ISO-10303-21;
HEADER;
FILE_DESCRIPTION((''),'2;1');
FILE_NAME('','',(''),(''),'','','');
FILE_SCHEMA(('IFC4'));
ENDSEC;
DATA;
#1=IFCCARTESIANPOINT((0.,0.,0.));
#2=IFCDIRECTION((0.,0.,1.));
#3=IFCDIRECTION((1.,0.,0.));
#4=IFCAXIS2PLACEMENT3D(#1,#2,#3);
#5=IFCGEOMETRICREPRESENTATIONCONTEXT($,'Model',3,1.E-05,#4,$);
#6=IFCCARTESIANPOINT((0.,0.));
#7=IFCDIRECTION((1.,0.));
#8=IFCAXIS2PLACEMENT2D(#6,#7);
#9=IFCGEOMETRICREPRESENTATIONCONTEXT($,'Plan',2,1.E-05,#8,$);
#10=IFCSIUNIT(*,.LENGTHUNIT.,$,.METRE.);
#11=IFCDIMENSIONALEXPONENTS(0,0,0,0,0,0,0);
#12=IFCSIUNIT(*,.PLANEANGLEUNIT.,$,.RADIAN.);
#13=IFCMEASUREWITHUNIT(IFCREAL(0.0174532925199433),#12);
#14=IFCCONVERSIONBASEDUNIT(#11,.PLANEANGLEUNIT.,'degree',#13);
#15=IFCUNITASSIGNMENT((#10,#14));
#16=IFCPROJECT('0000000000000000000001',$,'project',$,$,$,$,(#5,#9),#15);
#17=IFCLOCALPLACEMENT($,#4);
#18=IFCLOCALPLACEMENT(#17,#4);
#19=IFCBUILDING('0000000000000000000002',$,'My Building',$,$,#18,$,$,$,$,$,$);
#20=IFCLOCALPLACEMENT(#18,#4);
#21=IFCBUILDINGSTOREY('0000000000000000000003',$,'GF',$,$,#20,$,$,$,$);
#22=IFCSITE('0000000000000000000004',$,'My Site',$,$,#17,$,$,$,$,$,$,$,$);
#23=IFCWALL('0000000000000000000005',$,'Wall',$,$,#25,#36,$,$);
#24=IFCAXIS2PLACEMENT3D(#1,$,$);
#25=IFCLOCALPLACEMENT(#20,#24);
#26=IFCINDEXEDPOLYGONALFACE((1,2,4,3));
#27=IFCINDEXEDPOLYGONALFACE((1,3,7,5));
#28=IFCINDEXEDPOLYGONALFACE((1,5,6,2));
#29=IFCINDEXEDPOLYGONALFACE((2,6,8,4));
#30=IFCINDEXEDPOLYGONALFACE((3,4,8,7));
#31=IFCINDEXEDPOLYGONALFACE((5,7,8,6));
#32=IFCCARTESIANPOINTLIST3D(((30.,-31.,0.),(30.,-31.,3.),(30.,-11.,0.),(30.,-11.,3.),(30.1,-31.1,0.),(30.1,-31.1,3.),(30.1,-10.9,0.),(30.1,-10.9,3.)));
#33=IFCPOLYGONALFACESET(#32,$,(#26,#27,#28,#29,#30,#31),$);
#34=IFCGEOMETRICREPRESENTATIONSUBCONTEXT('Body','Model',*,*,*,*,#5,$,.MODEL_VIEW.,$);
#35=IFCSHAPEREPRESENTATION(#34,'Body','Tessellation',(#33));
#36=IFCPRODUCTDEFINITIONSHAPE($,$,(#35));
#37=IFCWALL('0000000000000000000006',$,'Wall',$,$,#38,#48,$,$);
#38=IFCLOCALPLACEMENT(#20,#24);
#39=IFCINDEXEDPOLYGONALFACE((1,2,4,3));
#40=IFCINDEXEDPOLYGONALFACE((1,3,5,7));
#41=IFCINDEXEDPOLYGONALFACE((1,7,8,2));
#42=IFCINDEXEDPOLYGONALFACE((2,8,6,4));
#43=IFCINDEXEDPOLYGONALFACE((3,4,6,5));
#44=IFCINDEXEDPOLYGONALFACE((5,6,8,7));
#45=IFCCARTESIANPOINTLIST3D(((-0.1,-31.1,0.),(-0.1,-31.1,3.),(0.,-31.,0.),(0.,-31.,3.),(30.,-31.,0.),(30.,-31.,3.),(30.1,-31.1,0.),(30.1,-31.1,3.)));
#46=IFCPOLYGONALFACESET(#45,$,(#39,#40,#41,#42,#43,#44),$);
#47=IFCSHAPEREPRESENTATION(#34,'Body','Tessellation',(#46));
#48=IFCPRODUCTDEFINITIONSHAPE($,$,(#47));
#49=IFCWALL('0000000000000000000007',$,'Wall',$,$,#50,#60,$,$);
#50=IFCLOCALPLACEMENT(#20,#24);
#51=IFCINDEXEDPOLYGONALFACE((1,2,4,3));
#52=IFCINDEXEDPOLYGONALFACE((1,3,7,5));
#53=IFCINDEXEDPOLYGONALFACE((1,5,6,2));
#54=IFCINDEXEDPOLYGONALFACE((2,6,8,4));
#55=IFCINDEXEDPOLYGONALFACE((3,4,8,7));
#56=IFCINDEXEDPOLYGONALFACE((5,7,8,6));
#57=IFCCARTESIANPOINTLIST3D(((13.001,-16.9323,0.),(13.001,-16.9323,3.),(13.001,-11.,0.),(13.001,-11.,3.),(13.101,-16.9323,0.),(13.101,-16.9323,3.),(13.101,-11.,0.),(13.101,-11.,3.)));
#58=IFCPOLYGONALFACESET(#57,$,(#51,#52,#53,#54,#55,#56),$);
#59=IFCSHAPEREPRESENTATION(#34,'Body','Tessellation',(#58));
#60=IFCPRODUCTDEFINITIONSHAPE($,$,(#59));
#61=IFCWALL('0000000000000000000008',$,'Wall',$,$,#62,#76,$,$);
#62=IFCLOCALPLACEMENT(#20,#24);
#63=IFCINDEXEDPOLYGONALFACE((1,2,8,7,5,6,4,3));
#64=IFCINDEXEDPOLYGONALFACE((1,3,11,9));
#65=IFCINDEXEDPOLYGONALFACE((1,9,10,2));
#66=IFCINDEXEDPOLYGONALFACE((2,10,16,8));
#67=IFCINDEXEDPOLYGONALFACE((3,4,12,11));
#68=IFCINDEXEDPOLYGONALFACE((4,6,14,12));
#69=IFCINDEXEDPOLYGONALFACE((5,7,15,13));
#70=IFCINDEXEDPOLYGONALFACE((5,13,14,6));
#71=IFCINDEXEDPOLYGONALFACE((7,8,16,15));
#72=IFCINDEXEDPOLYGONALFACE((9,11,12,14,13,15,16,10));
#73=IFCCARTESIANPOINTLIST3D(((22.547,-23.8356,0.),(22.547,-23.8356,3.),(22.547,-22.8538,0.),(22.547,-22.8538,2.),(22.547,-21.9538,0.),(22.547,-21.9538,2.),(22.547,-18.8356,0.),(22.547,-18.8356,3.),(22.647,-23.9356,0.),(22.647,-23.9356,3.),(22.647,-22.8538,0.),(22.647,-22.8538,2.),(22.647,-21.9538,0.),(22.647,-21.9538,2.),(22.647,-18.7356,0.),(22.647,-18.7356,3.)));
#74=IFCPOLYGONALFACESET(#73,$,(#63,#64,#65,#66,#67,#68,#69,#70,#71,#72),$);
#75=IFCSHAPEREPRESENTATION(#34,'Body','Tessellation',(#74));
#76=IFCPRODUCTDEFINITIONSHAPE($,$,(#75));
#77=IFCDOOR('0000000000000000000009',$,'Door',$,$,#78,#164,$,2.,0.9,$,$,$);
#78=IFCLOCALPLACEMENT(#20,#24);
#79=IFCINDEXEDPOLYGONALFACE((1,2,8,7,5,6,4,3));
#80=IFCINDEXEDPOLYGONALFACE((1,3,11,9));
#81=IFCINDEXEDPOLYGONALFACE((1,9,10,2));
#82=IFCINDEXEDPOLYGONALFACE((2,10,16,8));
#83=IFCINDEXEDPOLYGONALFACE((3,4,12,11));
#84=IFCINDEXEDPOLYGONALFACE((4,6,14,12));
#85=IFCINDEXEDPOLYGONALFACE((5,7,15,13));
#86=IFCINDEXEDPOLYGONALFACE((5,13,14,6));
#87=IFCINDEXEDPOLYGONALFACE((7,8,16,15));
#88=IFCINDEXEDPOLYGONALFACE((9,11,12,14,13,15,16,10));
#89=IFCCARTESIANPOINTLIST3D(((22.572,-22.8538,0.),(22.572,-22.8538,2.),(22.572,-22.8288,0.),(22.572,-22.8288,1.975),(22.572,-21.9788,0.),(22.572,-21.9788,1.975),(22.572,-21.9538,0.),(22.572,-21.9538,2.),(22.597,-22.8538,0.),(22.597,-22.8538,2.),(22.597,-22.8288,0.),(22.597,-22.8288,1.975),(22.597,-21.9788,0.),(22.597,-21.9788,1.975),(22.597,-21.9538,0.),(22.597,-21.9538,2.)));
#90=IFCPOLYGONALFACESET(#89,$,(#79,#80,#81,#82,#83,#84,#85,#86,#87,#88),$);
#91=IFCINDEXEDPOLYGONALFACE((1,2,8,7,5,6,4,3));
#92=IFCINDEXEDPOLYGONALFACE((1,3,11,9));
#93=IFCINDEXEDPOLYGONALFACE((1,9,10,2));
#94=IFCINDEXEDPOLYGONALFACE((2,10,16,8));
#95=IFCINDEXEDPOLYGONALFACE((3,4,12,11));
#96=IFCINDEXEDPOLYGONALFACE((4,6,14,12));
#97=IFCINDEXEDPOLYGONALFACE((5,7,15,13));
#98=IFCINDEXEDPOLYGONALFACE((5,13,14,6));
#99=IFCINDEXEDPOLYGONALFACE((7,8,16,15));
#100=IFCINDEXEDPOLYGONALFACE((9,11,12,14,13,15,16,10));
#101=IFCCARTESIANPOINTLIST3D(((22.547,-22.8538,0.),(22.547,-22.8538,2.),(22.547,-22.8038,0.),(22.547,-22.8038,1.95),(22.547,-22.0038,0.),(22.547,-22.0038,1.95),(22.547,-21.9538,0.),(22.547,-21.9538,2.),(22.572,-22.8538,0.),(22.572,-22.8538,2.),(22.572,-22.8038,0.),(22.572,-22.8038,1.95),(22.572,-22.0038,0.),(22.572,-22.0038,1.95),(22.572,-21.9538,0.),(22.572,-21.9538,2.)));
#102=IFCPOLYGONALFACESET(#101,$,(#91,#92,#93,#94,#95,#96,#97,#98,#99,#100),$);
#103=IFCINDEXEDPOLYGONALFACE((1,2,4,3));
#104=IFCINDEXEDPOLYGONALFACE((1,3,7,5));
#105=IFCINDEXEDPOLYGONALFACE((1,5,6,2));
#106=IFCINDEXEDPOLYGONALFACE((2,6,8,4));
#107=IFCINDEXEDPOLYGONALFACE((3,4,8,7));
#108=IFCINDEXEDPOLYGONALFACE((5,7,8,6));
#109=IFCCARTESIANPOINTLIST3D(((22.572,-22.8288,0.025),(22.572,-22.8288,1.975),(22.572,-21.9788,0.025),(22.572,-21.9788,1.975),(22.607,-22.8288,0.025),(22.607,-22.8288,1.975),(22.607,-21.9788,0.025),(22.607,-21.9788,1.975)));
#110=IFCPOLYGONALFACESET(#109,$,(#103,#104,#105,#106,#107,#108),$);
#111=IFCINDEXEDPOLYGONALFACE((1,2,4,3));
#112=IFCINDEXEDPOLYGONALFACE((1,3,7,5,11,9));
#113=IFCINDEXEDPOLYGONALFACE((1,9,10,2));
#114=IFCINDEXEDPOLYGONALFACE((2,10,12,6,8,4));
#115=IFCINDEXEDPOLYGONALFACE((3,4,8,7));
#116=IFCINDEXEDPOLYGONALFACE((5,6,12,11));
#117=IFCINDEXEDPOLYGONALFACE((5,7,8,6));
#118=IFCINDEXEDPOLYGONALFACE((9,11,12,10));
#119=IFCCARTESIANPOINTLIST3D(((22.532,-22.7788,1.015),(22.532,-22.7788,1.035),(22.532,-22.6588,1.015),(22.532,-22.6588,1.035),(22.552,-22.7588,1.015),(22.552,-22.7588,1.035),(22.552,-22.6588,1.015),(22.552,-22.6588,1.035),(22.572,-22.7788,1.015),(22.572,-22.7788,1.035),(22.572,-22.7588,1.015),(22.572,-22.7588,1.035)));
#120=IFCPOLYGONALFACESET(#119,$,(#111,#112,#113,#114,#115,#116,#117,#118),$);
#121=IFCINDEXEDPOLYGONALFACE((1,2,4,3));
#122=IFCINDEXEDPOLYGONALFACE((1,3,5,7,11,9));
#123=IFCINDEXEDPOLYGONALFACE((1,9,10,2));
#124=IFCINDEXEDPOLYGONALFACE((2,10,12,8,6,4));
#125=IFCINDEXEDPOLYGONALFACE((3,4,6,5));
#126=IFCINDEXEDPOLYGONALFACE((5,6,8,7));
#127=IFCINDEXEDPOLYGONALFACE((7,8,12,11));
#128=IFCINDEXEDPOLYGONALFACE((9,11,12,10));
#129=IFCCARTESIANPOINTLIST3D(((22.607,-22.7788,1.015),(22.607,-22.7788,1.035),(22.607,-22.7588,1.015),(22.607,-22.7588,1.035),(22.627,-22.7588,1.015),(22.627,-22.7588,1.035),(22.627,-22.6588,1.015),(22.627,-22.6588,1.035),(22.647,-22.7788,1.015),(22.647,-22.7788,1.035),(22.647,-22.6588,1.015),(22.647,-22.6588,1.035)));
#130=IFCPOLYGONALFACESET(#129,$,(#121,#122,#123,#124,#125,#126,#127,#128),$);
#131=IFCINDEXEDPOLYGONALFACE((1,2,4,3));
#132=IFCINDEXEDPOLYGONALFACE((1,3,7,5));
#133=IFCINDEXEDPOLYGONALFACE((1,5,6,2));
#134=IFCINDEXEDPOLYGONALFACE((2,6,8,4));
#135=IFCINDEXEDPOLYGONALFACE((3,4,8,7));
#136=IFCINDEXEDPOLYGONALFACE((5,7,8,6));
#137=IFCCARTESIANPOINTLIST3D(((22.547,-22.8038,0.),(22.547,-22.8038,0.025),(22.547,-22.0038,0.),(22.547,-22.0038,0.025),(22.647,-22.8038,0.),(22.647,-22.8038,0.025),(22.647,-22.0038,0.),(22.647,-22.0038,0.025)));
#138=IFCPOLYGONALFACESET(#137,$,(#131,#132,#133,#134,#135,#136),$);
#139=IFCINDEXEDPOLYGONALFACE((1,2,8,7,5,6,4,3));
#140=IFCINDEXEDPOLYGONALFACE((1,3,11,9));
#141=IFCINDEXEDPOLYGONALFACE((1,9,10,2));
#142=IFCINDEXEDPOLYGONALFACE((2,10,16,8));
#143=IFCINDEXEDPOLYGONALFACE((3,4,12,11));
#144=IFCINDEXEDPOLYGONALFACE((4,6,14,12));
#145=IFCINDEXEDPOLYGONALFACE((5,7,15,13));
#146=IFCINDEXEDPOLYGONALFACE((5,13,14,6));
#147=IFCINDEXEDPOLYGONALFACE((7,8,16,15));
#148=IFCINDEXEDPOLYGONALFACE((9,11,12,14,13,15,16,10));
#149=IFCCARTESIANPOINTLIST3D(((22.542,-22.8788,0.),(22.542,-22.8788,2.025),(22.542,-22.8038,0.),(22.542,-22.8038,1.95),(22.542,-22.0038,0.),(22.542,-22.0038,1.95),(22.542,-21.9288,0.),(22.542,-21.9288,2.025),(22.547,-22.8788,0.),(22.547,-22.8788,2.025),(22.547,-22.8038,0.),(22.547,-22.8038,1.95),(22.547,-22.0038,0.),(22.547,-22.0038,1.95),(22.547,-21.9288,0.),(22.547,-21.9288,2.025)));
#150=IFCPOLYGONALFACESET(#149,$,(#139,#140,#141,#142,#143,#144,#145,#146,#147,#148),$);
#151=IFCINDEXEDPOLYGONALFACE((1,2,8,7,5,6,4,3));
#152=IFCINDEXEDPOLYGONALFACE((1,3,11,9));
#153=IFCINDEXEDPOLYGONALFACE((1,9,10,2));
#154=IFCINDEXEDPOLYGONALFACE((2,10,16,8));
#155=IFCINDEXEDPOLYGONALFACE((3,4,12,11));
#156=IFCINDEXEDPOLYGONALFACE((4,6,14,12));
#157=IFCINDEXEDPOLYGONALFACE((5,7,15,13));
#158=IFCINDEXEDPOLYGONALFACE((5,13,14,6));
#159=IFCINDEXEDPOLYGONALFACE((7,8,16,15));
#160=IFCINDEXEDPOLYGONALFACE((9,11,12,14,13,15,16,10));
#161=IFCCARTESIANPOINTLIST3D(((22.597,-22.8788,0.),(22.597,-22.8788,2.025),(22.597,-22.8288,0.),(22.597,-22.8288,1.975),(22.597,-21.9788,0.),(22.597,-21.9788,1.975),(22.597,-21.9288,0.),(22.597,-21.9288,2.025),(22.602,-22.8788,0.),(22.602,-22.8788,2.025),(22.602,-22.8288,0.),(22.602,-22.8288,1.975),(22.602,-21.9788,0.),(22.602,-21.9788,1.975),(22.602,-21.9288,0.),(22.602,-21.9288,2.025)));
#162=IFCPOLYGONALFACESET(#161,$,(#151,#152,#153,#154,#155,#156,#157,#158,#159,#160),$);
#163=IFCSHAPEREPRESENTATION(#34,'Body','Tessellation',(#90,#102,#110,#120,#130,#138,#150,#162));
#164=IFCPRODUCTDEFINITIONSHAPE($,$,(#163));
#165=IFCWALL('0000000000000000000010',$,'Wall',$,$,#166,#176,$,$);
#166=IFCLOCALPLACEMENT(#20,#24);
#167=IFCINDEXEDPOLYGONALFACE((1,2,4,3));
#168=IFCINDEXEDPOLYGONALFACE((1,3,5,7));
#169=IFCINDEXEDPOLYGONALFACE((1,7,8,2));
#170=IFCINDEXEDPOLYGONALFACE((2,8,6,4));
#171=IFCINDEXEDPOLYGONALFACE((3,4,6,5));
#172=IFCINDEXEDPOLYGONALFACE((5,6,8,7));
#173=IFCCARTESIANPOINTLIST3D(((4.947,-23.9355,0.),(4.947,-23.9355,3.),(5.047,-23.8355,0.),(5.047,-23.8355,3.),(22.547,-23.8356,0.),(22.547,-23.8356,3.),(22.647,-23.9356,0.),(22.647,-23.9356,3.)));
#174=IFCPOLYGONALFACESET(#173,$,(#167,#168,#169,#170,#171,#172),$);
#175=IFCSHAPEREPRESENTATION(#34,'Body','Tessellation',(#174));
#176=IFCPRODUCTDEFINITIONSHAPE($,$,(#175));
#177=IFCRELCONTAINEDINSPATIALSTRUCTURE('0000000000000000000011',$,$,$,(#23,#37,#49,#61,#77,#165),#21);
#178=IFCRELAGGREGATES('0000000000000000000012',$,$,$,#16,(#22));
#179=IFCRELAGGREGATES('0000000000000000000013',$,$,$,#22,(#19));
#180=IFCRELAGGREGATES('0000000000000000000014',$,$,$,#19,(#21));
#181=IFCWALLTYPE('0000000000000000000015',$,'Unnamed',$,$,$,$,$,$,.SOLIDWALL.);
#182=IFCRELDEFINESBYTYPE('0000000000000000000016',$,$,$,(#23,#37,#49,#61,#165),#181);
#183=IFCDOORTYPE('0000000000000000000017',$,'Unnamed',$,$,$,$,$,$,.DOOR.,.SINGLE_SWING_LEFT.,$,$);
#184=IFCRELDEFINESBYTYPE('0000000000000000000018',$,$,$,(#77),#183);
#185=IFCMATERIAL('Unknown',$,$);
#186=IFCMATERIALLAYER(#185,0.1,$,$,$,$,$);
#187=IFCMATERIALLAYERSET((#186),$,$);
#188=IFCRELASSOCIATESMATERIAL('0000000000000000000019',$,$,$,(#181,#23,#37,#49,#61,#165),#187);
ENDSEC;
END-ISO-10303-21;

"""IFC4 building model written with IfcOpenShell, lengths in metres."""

from ifc_helpers import new_model, entity, si_unit, converted_unit, frame, origin_with_axes, origin_2d_with_axis, place, context, subcontext, project, spatial, line, indexed_curve, outline, extrude, shape, source, transform, mapped, material, layer, layer_set, layer_usage, type_object, type_shapes, element, fill, save


model = new_model("IFC4")

# Units and contexts
model_context = context("Model", 3, precision=1e-05, world=origin_with_axes())
plan_context = context("Plan", 2, precision=1e-05, world=origin_2d_with_axis())
body_context_1 = subcontext(model_context, "Body", "Model", "MODEL_VIEW")
body_context_2 = subcontext(plan_context, "Body", "Plan", "PLAN_VIEW")
ifc_project = project(units=[si_unit("LENGTHUNIT", "METRE"), converted_unit("PLANEANGLEUNIT", "degree", entity("IfcReal", 0.0174532925199433), si_unit("PLANEANGLEUNIT", "RADIAN"), dimensions=[0, 0, 0, 0, 0, 0, 0])], contexts=[model_context, plan_context])

# Site, building, storey
site_placement = place(None, origin_with_axes())
site = spatial("IfcSite", under=ifc_project, at=site_placement, Name="My Site")
building_placement = place(site_placement, origin_with_axes())
building = spatial("IfcBuilding", under=site, at=building_placement, Name="My Building")
storey_placement = place(building_placement, origin_with_axes())
storey = spatial("IfcBuildingStorey", under=building, at=storey_placement, Name="GF")

# Walls
ifc_material = material(Name="Unknown")
ifc_layer = layer(ifc_material, 0.1)
ifc_layer_set = layer_set([ifc_layer])
ifc_layer_usage_1 = layer_usage(ifc_layer_set, "AXIS2", "POSITIVE", 0.0)
wall_type = type_object("IfcWallType", Name="Unnamed", PredefinedType="SOLIDWALL", material=ifc_layer_set)
wall_1_placement = place(storey_placement, frame((30.0, -11.0, 0.0), z_axis=(0.0, 0.0, 1.0), x_axis=(0.0, -1.0, 0.0)))
element("IfcWall", 1, at=wall_1_placement, inside=storey, type_object=wall_type, material=ifc_layer_usage_1, Name="Wall", context=body_context_1, shape_type="SweptSolid", body=[
    extrude(outline(indexed_curve([(0.0, 0.0), (-0.1, 0.1), (20.1, 0.1), (20.0, 0.0)], segments=[line(1, 2, 3, 4, 1)])), origin_with_axes(), (0.0, 0.0, 1.0), 3.0),
])
ifc_layer_usage_2 = layer_usage(ifc_layer_set, "AXIS2", "POSITIVE", 0.0)
wall_2_placement = place(storey_placement, frame((30.0, -31.0, 0.0), z_axis=(0.0, 0.0, 1.0), x_axis=(-1.0, 0.0, 0.0)))
element("IfcWall", 2, at=wall_2_placement, inside=storey, type_object=wall_type, material=ifc_layer_usage_2, Name="Wall", context=body_context_1, shape_type="SweptSolid", body=[
    extrude(outline(indexed_curve([(0.0, 0.0), (-0.1, 0.1), (30.1, 0.1), (30.0, 0.0)], segments=[line(1, 2, 3, 4, 1)])), origin_with_axes(), (0.0, 0.0, 1.0), 3.0),
])
ifc_layer_usage_3 = layer_usage(ifc_layer_set, "AXIS2", "POSITIVE", 0.0)
wall_3_placement = place(storey_placement, frame((13.101, -16.9323, 0.0), z_axis=(0.0, 0.0, 1.0), x_axis=(0.0, 1.0, 0.0)))
element("IfcWall", 3, at=wall_3_placement, inside=storey, type_object=wall_type, material=ifc_layer_usage_3, Name="Wall", context=body_context_1, shape_type="SweptSolid", body=[
    extrude(outline(indexed_curve([(0.0, 0.0), (0.0, 0.1), (5.9323, 0.1), (5.9323, 0.0)], segments=[line(1, 2, 3, 4, 1)])), origin_with_axes(), (0.0, 0.0, 1.0), 3.0),
])

# Wall, opening, door
ifc_layer_usage_4 = layer_usage(ifc_layer_set, "AXIS2", "POSITIVE", 0.0)
wall_4_placement = place(storey_placement, frame((22.547, -18.8356, 0.0), z_axis=(0.0, 0.0, 1.0), x_axis=(0.0, -1.0, 0.0)))
wall_4 = element("IfcWall", 4, at=wall_4_placement, inside=storey, type_object=wall_type, material=ifc_layer_usage_4, Name="Wall", context=body_context_1, shape_type="SweptSolid", body=[
    extrude(outline(indexed_curve([(0.0, 0.0), (-0.1, 0.1), (5.1, 0.1), (5.0, 0.0)], segments=[line(1, 2, 3, 4, 1)])), origin_with_axes(), (0.0, 0.0, 1.0), 3.0),
])
shared_shape_1 = source(origin_with_axes(), body_context_1, "Body", "SweptSolid", [
    extrude(outline(indexed_curve([(0.0, 0.0), (0.9, 0.0), (0.9, 2.0), (0.0, 2.0)], segments=[line(1, 2, 3, 4, 1)])), frame((0.0, -0.6, 0.0), z_axis=(0.0, -1.0, 0.0), x_axis=(1.0, 0.0, 0.0)), (0.0, 0.0, -1.0), 1.2),
])
opening_1_placement = place(wall_4_placement, frame((3.1182, 0.0, 0.0), z_axis=(0.0, 0.0, 1.0), x_axis=(1.0, 0.0, 0.0)))
opening_1 = element("IfcOpeningElement", 5, at=opening_1_placement, cuts=wall_4, PredefinedType="OPENING", context=body_context_1, shape_type="MappedRepresentation", body=[
    mapped(shared_shape_1, transform((0.0, 0.0, 0.0), x_axis=(1.0, 0.0, 0.0), y_axis=(0.0, 1.0, 0.0), z_axis=(0.0, 0.0, 1.0), scale=1.0)),
])
door_type = type_object("IfcDoorType", Name="Unnamed", OperationType="SINGLE_SWING_LEFT", PredefinedType="DOOR")
shared_shape_2 = source(origin_with_axes(), body_context_1, "Body", "SweptSolid", [
    extrude(outline(indexed_curve([(0.0, 0.0), (0.0, 2.0), (0.9, 2.0), (0.9, 0.0), (0.875, 0.0), (0.875, 1.975), (0.025, 1.975), (0.025, 0.0)], segments=[line(1, 2, 3, 4, 5, 6, 7, 8, 1)])), frame((0.0, 0.025, 0.0), z_axis=(0.0, -1.0, 0.0), x_axis=(1.0, 0.0, 0.0)), (0.0, 0.0, -1.0), 0.025),
    extrude(outline(indexed_curve([(0.0, 0.0), (0.0, 2.0), (0.9, 2.0), (0.9, 0.0), (0.85, 0.0), (0.85, 1.95), (0.05, 1.95), (0.05, 0.0)], segments=[line(1, 2, 3, 4, 5, 6, 7, 8, 1)])), frame((0.0, 0.0, 0.0), z_axis=(0.0, -1.0, 0.0), x_axis=(1.0, 0.0, 0.0)), (0.0, 0.0, -1.0), 0.025),
    extrude(outline(indexed_curve([(0.0, 0.0), (0.85, 0.0), (0.85, 0.035), (0.0, 0.035)], segments=[line(1, 2, 3, 4, 1)])), frame((0.025, 0.025, 0.025), z_axis=(0.0, 0.0, 1.0), x_axis=(1.0, 0.0, 0.0)), (0.0, 0.0, 1.0), 1.95),
    extrude(outline(indexed_curve([(0.0, 0.0), (0.0, -0.04), (-0.12, -0.04), (-0.12, -0.02), (-0.02, -0.02), (-0.02, 0.0)], segments=[line(1, 2, 3, 4, 5, 6, 1)])), frame((0.825, 0.025, 1.015), z_axis=(0.0, 0.0, 1.0), x_axis=(1.0, 0.0, 0.0)), (0.0, 0.0, 1.0), 0.02),
    extrude(outline(indexed_curve([(0.0, 0.0), (0.0, 0.04), (-0.12, 0.04), (-0.12, 0.02), (-0.02, 0.02), (-0.02, 0.0)], segments=[line(1, 2, 3, 4, 5, 6, 1)])), frame((0.825, 0.06, 1.015), z_axis=(0.0, 0.0, 1.0), x_axis=(1.0, 0.0, 0.0)), (0.0, 0.0, 1.0), 0.02),
    extrude(outline(indexed_curve([(0.0, 0.0), (0.8, 0.0), (0.8, 0.1), (0.0, 0.1)], segments=[line(1, 2, 3, 4, 1)])), frame((0.05, 0.0, 0.0), z_axis=(0.0, 0.0, 1.0), x_axis=(1.0, 0.0, 0.0)), (0.0, 0.0, 1.0), 0.025),
    extrude(outline(indexed_curve([(0.0, 0.0), (0.0, 2.025), (0.95, 2.025), (0.95, 0.0), (0.875, 0.0), (0.875, 1.95), (0.075, 1.95), (0.075, 0.0)], segments=[line(1, 2, 3, 4, 5, 6, 7, 8, 1)])), frame((-0.025, -0.005, 0.0), z_axis=(0.0, -1.0, 0.0), x_axis=(1.0, 0.0, 0.0)), (0.0, 0.0, -1.0), 0.005),
    extrude(outline(indexed_curve([(0.0, 0.0), (0.0, 2.025), (0.95, 2.025), (0.95, 0.0), (0.9, 0.0), (0.9, 1.975), (0.05, 1.975), (0.05, 0.0)], segments=[line(1, 2, 3, 4, 5, 6, 7, 8, 1)])), frame((-0.025, 0.05, 0.0), z_axis=(0.0, -1.0, 0.0), x_axis=(1.0, 0.0, 0.0)), (0.0, 0.0, -1.0), 0.005),
])
shared_shape_3 = source(origin_with_axes(), body_context_2, "Body", "Curve2D", [
    entity("IfcIndexedPolyCurve", entity("IfcCartesianPointList2D", [[0.0, 0.0], [0.0, 0.05], [0.025, 0.05], [0.025, 0.025], [0.05, 0.025], [0.05, 0.0]]), [entity("IfcLineIndex", [1, 2, 3, 4, 5, 6, 1])]),
    entity("IfcIndexedPolyCurve", entity("IfcCartesianPointList2D", [[0.9, 0.0], [0.9, 0.05], [0.875, 0.05], [0.875, 0.025], [0.85, 0.025], [0.85, 0.0]]), [entity("IfcLineIndex", [1, 2, 3, 4, 5, 6, 1])]),
    entity("IfcTrimmedCurve", entity("IfcEllipse", entity("IfcAxis2Placement2D", entity("IfcCartesianPoint", [0.06, 0.05]), entity("IfcDirection", [1.0, 0.0])), 0.815, 0.85), [entity("IfcCartesianPoint", [0.875, 0.05])], [entity("IfcCartesianPoint", [0.06, 0.9])], True, "CARTESIAN"),
    entity("IfcIndexedPolyCurve", entity("IfcCartesianPointList2D", [[0.025, 0.05], [0.06, 0.05], [0.06, 0.9], [0.025, 0.9]]), [entity("IfcLineIndex", [1, 2, 3, 4, 1])]),
])
type_shapes(door_type, [shared_shape_2, shared_shape_3])
door_1_placement = place(opening_1_placement, frame((0.0, 0.0, 0.0), z_axis=(0.0, 0.0, 1.0), x_axis=(1.0, 0.0, 0.0)))
door_1 = element("IfcDoor", 6, at=door_1_placement, inside=storey, type_object=door_type, Name="Door", OverallHeight=2.0, OverallWidth=0.9, shapes=[
    shape(body_context_1, "Body", "MappedRepresentation", [mapped(shared_shape_2, transform((0.0, 0.0, 0.0), x_axis=(1.0, 0.0, 0.0), y_axis=(0.0, 1.0, 0.0), z_axis=(0.0, 0.0, 1.0), scale=1.0))]),
    shape(body_context_2, "Body", "MappedRepresentation", [mapped(shared_shape_3, transform((0.0, 0.0, 0.0), x_axis=(1.0, 0.0, 0.0), y_axis=(0.0, 1.0, 0.0), z_axis=(0.0, 0.0, 1.0), scale=1.0))]),
])
fill(opening_1, door_1)

# Wall
ifc_layer_usage_5 = layer_usage(ifc_layer_set, "AXIS2", "POSITIVE", 0.0)
wall_5_placement = place(storey_placement, frame((22.547, -23.8356, 0.0), z_axis=(0.0, 0.0, 1.0), x_axis=(-1.0, 0.0, 0.0)))
element("IfcWall", 7, at=wall_5_placement, inside=storey, type_object=wall_type, material=ifc_layer_usage_5, Name="Wall", context=body_context_1, shape_type="SweptSolid", body=[
    extrude(outline(indexed_curve([(0.0, 0.0), (-0.1, 0.1), (17.6, 0.1), (17.5, 0.0)], segments=[line(1, 2, 3, 4, 1)])), origin_with_axes(), (0.0, 0.0, 1.0), 3.0),
])

save(model, "model.ifc")
